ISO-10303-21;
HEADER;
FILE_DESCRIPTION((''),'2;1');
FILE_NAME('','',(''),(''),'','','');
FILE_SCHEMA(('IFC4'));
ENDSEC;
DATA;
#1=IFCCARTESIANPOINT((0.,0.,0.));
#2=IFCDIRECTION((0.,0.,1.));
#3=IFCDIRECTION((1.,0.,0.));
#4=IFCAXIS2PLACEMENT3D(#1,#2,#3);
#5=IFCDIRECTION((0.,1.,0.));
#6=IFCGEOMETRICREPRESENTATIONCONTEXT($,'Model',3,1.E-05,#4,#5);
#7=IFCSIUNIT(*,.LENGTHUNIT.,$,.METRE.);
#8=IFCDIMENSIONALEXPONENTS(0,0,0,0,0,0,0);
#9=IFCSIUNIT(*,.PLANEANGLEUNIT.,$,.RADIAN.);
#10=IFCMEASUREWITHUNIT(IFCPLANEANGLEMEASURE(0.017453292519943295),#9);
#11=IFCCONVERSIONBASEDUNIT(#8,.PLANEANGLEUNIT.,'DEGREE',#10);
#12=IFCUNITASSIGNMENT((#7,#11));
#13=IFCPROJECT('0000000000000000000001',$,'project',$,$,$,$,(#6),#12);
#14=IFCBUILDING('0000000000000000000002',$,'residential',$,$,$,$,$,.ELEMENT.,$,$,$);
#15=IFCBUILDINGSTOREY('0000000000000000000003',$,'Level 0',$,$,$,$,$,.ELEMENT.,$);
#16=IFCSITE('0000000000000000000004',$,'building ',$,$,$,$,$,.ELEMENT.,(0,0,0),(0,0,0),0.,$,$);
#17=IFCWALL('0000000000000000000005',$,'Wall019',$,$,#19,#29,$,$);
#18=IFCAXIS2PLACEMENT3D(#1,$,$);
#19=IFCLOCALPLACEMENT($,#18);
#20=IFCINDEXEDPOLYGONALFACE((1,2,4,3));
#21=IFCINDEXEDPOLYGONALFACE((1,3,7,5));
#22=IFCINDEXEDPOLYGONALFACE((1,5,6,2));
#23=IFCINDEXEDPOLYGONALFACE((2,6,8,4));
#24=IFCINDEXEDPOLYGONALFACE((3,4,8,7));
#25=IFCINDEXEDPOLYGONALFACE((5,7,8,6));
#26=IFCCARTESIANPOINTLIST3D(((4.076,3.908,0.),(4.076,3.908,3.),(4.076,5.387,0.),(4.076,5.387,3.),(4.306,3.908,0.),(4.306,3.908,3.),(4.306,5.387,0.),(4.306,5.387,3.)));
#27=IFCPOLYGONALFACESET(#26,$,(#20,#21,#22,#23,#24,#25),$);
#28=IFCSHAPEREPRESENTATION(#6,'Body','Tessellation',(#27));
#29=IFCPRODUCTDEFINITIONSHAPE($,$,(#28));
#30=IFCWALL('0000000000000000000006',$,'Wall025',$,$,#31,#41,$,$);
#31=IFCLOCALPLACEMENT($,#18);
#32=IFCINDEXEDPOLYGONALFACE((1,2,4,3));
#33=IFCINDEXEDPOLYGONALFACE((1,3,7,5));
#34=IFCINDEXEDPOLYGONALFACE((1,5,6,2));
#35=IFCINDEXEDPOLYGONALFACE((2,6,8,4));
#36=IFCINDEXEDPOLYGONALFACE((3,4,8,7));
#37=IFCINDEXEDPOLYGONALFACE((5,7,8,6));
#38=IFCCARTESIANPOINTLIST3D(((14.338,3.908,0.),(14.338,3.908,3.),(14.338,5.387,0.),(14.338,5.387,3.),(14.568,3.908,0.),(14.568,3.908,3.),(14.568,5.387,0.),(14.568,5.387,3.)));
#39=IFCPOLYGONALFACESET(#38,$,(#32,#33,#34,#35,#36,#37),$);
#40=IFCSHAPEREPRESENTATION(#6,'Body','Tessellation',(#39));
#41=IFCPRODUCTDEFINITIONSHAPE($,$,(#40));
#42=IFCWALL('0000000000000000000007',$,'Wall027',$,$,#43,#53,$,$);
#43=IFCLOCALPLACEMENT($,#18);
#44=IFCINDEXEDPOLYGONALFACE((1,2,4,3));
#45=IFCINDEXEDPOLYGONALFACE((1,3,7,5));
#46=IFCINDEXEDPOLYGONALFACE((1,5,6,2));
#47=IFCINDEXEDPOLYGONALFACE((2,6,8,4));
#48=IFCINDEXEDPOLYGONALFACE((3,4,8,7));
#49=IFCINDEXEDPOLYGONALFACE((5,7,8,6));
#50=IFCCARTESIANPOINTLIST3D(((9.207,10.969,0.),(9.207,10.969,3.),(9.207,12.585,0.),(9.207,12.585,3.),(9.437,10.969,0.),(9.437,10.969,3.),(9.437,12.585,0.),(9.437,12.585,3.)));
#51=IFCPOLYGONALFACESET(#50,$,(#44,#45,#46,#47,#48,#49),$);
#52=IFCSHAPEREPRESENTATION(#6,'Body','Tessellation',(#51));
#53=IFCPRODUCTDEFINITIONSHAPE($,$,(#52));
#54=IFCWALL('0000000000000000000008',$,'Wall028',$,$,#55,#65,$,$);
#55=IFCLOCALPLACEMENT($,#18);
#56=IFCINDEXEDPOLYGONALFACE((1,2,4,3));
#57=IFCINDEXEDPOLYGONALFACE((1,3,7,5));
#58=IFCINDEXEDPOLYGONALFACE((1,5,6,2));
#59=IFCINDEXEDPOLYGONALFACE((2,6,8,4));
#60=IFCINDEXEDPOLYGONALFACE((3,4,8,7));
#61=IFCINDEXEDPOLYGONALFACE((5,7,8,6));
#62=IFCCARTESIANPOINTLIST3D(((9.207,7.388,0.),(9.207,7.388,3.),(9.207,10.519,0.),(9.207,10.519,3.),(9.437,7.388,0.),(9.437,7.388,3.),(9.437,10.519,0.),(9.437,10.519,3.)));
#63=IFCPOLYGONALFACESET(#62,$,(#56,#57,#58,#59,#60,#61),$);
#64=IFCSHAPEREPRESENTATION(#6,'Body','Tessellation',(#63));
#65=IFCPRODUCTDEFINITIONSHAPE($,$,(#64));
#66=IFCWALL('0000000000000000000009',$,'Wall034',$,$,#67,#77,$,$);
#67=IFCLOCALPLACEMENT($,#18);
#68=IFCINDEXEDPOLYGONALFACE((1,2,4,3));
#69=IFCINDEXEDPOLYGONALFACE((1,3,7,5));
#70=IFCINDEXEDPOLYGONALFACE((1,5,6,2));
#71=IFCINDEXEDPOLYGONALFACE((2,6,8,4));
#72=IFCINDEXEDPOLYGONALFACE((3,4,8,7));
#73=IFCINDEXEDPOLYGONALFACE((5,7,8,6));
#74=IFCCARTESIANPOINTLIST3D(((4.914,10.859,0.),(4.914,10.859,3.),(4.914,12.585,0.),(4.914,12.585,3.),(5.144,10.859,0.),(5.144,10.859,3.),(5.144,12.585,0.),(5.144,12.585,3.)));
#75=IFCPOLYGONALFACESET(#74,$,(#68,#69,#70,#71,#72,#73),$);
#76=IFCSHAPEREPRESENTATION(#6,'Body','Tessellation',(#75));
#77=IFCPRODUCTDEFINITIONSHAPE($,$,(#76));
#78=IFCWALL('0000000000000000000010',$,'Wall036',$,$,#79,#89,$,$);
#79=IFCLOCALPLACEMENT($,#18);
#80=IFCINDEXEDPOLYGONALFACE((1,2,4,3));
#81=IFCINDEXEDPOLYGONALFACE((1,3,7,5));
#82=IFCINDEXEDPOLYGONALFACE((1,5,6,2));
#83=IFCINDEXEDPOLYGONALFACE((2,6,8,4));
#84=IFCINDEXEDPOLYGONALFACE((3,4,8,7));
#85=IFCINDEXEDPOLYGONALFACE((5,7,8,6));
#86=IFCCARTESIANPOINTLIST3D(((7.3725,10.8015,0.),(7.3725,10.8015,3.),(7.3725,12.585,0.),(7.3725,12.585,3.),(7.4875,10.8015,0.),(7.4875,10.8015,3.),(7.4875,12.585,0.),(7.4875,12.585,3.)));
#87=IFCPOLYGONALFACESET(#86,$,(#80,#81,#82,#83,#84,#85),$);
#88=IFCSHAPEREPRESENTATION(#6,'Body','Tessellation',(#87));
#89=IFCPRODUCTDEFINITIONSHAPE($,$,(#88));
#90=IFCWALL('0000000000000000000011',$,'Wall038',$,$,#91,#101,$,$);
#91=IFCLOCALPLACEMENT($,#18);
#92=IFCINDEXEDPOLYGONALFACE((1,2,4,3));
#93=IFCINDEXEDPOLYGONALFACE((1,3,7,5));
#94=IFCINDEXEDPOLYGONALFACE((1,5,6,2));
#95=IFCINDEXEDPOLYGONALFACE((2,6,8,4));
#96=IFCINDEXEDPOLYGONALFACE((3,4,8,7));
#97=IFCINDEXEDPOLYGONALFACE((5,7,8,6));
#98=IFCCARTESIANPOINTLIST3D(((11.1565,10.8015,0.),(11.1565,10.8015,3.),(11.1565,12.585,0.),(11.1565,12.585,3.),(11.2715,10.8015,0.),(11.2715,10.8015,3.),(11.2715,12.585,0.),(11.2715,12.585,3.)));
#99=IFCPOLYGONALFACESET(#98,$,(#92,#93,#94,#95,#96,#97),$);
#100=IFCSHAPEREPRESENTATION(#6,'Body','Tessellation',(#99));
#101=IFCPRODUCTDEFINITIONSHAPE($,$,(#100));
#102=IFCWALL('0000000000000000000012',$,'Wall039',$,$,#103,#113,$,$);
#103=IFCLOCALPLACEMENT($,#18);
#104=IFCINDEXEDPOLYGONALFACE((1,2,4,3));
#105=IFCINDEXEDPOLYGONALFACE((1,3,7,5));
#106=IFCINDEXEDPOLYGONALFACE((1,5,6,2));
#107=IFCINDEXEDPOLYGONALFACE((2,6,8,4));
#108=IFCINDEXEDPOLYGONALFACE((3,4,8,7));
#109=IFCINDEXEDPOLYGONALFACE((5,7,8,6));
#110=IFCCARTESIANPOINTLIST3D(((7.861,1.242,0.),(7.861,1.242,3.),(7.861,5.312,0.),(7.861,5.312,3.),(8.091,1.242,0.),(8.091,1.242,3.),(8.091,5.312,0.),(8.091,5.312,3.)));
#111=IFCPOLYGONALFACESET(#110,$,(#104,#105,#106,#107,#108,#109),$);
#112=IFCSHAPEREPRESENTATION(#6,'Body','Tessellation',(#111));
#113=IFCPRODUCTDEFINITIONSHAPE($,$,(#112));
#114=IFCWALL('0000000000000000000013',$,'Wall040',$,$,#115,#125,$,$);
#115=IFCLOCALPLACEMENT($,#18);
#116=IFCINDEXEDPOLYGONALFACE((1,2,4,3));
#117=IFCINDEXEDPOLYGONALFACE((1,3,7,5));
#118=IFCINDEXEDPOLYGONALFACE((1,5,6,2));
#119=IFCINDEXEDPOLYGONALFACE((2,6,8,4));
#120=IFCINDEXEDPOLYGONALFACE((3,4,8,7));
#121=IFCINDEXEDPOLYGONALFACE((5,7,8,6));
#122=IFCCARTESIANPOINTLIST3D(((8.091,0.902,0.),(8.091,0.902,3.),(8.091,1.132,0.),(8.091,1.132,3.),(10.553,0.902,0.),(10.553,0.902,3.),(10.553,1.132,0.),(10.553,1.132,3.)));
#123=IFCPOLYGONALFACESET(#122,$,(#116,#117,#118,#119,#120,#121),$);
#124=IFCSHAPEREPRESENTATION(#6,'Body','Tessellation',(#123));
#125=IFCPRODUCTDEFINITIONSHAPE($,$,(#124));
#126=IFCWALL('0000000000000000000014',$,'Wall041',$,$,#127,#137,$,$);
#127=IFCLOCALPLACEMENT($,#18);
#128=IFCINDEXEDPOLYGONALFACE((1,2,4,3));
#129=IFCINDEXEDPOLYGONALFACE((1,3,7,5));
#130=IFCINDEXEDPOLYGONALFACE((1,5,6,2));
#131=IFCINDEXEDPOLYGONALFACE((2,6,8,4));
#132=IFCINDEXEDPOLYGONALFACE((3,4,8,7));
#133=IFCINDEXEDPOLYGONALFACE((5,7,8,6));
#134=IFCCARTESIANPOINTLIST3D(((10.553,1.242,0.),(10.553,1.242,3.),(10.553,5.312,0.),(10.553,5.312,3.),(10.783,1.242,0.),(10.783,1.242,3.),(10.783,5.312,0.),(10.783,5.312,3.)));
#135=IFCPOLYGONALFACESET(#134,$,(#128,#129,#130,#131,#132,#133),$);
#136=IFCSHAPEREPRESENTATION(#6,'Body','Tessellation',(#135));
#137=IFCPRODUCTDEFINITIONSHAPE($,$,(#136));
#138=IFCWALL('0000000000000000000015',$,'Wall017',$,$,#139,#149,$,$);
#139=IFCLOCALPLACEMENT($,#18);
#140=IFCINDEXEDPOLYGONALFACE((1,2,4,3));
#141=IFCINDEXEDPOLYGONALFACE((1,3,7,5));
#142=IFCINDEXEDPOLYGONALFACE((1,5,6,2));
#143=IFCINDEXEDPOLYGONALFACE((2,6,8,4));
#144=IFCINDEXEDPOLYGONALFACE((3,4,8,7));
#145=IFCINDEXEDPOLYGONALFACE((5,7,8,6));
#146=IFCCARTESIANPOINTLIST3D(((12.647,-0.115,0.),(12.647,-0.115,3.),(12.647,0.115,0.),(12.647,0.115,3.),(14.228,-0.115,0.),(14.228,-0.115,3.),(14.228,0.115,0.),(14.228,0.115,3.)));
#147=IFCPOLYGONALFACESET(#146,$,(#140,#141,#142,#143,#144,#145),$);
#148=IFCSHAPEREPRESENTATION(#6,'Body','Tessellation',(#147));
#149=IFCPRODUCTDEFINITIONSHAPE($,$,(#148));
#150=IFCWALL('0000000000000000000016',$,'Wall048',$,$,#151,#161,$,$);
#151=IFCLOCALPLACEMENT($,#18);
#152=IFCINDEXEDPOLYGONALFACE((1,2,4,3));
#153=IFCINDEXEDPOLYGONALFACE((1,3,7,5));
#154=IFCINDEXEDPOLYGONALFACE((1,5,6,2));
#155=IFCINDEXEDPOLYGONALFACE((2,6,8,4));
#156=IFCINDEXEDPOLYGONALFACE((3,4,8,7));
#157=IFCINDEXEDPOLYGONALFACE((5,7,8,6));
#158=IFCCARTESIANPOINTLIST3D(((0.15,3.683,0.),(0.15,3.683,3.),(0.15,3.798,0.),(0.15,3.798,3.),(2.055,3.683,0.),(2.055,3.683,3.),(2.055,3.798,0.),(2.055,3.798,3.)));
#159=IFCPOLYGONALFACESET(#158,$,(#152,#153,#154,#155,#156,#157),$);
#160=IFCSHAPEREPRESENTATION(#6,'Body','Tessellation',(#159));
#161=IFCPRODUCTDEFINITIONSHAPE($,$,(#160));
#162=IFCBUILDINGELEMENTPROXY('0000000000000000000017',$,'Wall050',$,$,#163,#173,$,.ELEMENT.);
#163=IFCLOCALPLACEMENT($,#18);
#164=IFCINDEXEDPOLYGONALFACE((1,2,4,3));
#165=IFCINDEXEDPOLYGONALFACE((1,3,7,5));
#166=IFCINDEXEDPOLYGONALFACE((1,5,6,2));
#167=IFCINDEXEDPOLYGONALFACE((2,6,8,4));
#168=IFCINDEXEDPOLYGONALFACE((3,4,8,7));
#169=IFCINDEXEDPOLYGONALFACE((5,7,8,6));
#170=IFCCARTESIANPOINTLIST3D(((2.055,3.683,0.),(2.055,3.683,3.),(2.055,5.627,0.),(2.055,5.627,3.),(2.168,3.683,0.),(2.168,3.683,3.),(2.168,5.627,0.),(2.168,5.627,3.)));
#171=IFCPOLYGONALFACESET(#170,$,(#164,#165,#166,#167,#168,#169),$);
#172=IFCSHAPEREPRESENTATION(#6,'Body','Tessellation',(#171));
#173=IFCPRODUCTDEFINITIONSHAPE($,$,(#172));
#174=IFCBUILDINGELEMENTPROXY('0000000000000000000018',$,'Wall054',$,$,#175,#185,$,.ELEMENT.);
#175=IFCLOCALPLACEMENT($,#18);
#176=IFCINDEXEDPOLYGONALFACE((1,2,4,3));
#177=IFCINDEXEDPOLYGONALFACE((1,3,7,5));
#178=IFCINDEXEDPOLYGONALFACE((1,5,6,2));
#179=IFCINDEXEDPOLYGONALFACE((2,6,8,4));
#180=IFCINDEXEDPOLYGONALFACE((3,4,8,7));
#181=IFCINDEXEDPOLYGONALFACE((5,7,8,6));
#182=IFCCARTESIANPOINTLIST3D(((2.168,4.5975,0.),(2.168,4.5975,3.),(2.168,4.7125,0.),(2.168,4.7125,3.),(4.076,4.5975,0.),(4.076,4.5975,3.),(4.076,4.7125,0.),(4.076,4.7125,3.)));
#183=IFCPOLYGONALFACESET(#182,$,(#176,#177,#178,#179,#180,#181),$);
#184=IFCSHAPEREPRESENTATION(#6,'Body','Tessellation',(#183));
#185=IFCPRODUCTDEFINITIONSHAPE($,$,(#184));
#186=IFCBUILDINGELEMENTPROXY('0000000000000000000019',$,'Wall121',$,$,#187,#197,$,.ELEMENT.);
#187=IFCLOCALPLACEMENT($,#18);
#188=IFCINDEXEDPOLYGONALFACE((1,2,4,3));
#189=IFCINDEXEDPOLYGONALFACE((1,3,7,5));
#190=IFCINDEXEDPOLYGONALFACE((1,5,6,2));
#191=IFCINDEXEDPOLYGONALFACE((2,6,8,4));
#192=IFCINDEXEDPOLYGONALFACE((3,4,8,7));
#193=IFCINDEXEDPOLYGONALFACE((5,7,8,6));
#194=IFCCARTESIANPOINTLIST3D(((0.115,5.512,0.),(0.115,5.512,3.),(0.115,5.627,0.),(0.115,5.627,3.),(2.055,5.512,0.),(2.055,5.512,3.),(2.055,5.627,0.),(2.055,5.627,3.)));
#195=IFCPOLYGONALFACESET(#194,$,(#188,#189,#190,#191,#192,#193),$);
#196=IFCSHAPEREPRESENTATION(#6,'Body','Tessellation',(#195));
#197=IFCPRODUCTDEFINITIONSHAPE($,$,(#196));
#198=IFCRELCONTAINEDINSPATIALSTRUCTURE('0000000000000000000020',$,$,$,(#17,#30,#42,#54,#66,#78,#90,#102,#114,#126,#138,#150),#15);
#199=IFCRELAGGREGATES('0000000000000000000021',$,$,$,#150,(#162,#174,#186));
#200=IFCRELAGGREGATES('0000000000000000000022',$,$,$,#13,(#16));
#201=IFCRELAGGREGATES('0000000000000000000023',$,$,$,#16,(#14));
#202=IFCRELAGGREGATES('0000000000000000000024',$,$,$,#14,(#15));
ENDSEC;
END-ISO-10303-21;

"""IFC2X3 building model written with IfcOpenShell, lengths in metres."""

from ifc_helpers import new_model, entity, si_unit, converted_unit, direction, frame, frame_2d, origin_with_axes, place, context, project, spatial, rectangle, extrude, element, aggregate, save


model = new_model("IFC2X3")

# Units and contexts
model_context = context("Model", 3, precision=1e-05, world=origin_with_axes(), true_north=direction((0.0, 1.0, 0.0)))
ifc_project = project(units=[si_unit("LENGTHUNIT", "METRE"), converted_unit("PLANEANGLEUNIT", "DEGREE", entity("IfcPlaneAngleMeasure", 0.017453292519943295), si_unit("PLANEANGLEUNIT", "RADIAN"), dimensions=[0, 0, 0, 0, 0, 0, 0])], contexts=[model_context])

# Site, building, storey
site = spatial("IfcSite", under=ifc_project, Name="building ", CompositionType="ELEMENT", RefLatitude=(0, 0, 0), RefLongitude=(0, 0, 0), RefElevation=0.0)
building = spatial("IfcBuilding", under=site, Name="residential", CompositionType="ELEMENT")
storey = spatial("IfcBuildingStorey", under=building, Name="Level 0", CompositionType="ELEMENT")

# Shared definitions
placement = place(None, origin_with_axes())

# Walls
element("IfcWall", 1, at=placement, inside=storey, Name="Wall019", context=model_context, shape_type="SweptSolid", body=[
    extrude(rectangle(XDim=1.479, YDim=0.23, at=frame_2d((0.0, 0.0), x_axis=(0.0, -1.0, 0.0))), frame((4.191, 4.6475, 0.0), z_axis=(0.0, 0.0, 1.0), x_axis=(1.0, 0.0, 0.0)), (0.0, 0.0, 1.0), 3.0),
])
element("IfcWall", 2, at=placement, inside=storey, Name="Wall025", context=model_context, shape_type="SweptSolid", body=[
    extrude(rectangle(XDim=1.479, YDim=0.23, at=frame_2d((0.0, 0.0), x_axis=(0.0, 1.0, 0.0))), frame((14.453, 4.6475, 0.0), z_axis=(0.0, 0.0, 1.0), x_axis=(1.0, 0.0, 0.0)), (0.0, 0.0, 1.0), 3.0),
])
element("IfcWall", 3, at=placement, inside=storey, Name="Wall027", context=model_context, shape_type="SweptSolid", body=[
    extrude(rectangle(XDim=1.616, YDim=0.23, at=frame_2d((0.0, 0.0), x_axis=(0.0, -1.0, 0.0))), frame((9.322, 11.777, 0.0), z_axis=(0.0, 0.0, 1.0), x_axis=(1.0, 0.0, 0.0)), (0.0, 0.0, 1.0), 3.0),
])
element("IfcWall", 4, at=placement, inside=storey, Name="Wall028", context=model_context, shape_type="SweptSolid", body=[
    extrude(rectangle(XDim=3.131, YDim=0.23, at=frame_2d((0.0, 0.0), x_axis=(0.0, -1.0, 0.0))), frame((9.322, 8.9535, 0.0), z_axis=(0.0, 0.0, 1.0), x_axis=(1.0, 0.0, 0.0)), (0.0, 0.0, 1.0), 3.0),
])
element("IfcWall", 5, at=placement, inside=storey, Name="Wall034", context=model_context, shape_type="SweptSolid", body=[
    extrude(rectangle(XDim=1.726, YDim=0.23, at=frame_2d((0.0, 0.0), x_axis=(0.0, 1.0, 0.0))), frame((5.029, 11.722, 0.0), z_axis=(0.0, 0.0, 1.0), x_axis=(1.0, 0.0, 0.0)), (0.0, 0.0, 1.0), 3.0),
])
element("IfcWall", 6, at=placement, inside=storey, Name="Wall036", context=model_context, shape_type="SweptSolid", body=[
    extrude(rectangle(XDim=1.7835, YDim=0.115, at=frame_2d((0.0, 0.0), x_axis=(0.0, -1.0, 0.0))), frame((7.43, 11.6933, 0.0), z_axis=(0.0, 0.0, 1.0), x_axis=(1.0, 0.0, 0.0)), (0.0, 0.0, 1.0), 3.0),
])
element("IfcWall", 7, at=placement, inside=storey, Name="Wall038", context=model_context, shape_type="SweptSolid", body=[
    extrude(rectangle(XDim=1.7835, YDim=0.115, at=frame_2d((0.0, 0.0), x_axis=(0.0, -1.0, 0.0))), frame((11.214, 11.6933, 0.0), z_axis=(0.0, 0.0, 1.0), x_axis=(1.0, 0.0, 0.0)), (0.0, 0.0, 1.0), 3.0),
])
element("IfcWall", 8, at=placement, inside=storey, Name="Wall039", context=model_context, shape_type="SweptSolid", body=[
    extrude(rectangle(XDim=4.07, YDim=0.23, at=frame_2d((0.0, 0.0), x_axis=(0.0, -1.0, 0.0))), frame((7.976, 3.277, 0.0), z_axis=(0.0, 0.0, 1.0), x_axis=(1.0, 0.0, 0.0)), (0.0, 0.0, 1.0), 3.0),
])
element("IfcWall", 9, at=placement, inside=storey, Name="Wall040", context=model_context, shape_type="SweptSolid", body=[
    extrude(rectangle(XDim=2.462, YDim=0.23, at=frame_2d((0.0, 0.0), x_axis=(1.0, 0.0, 0.0))), frame((9.322, 1.017, 0.0), z_axis=(0.0, 0.0, 1.0), x_axis=(1.0, 0.0, 0.0)), (0.0, 0.0, 1.0), 3.0),
])
element("IfcWall", 10, at=placement, inside=storey, Name="Wall041", context=model_context, shape_type="SweptSolid", body=[
    extrude(rectangle(XDim=4.07, YDim=0.23, at=frame_2d((0.0, 0.0), x_axis=(0.0, -1.0, 0.0))), frame((10.668, 3.277, 0.0), z_axis=(0.0, 0.0, 1.0), x_axis=(1.0, 0.0, 0.0)), (0.0, 0.0, 1.0), 3.0),
])
element("IfcWall", 11, at=placement, inside=storey, Name="Wall017", context=model_context, shape_type="SweptSolid", body=[
    extrude(rectangle(XDim=1.581, YDim=0.23, at=frame_2d((0.0, 0.0), x_axis=(-1.0, 0.0, 0.0))), frame((13.4375, 0.0, 0.0), z_axis=(0.0, 0.0, 1.0), x_axis=(1.0, 0.0, 0.0)), (0.0, 0.0, 1.0), 3.0),
])

# Wall
wall_1 = element("IfcWall", 12, at=placement, inside=storey, Name="Wall048", context=model_context, shape_type="SweptSolid", body=[
    extrude(rectangle(XDim=1.905, YDim=0.115, at=frame_2d((0.0, 0.0), x_axis=(1.0, 0.0, 0.0))), frame((1.1025, 3.7405, 0.0), z_axis=(0.0, 0.0, 1.0), x_axis=(1.0, 0.0, 0.0)), (0.0, 0.0, 1.0), 3.0),
])

# Building element proxies
proxy_1 = element("IfcBuildingElementProxy", 13, at=placement, Name="Wall050", CompositionType="ELEMENT", context=model_context, shape_type="SweptSolid", body=[
    extrude(rectangle(XDim=1.944, YDim=0.113, at=frame_2d((0.0, 0.0), x_axis=(0.0, 1.0, 0.0))), frame((2.1115, 4.655, 0.0), z_axis=(0.0, 0.0, 1.0), x_axis=(1.0, 0.0, 0.0)), (0.0, 0.0, 1.0), 3.0),
])
proxy_2 = element("IfcBuildingElementProxy", 14, at=placement, Name="Wall054", CompositionType="ELEMENT", context=model_context, shape_type="SweptSolid", body=[
    extrude(rectangle(XDim=1.908, YDim=0.115, at=frame_2d((0.0, 0.0), x_axis=(1.0, 0.0, 0.0))), frame((3.122, 4.655, 0.0), z_axis=(0.0, 0.0, 1.0), x_axis=(1.0, 0.0, 0.0)), (0.0, 0.0, 1.0), 3.0),
])
proxy_3 = element("IfcBuildingElementProxy", 15, at=placement, Name="Wall121", CompositionType="ELEMENT", context=model_context, shape_type="SweptSolid", body=[
    extrude(rectangle(XDim=1.94, YDim=0.115, at=frame_2d((0.0, 0.0), x_axis=(-1.0, 0.0, 0.0))), frame((1.085, 5.5695, 0.0), z_axis=(0.0, 0.0, 1.0), x_axis=(1.0, 0.0, 0.0)), (0.0, 0.0, 1.0), 3.0),
])
aggregate(wall_1, [proxy_1, proxy_2, proxy_3])

save(model, "model.ifc")
